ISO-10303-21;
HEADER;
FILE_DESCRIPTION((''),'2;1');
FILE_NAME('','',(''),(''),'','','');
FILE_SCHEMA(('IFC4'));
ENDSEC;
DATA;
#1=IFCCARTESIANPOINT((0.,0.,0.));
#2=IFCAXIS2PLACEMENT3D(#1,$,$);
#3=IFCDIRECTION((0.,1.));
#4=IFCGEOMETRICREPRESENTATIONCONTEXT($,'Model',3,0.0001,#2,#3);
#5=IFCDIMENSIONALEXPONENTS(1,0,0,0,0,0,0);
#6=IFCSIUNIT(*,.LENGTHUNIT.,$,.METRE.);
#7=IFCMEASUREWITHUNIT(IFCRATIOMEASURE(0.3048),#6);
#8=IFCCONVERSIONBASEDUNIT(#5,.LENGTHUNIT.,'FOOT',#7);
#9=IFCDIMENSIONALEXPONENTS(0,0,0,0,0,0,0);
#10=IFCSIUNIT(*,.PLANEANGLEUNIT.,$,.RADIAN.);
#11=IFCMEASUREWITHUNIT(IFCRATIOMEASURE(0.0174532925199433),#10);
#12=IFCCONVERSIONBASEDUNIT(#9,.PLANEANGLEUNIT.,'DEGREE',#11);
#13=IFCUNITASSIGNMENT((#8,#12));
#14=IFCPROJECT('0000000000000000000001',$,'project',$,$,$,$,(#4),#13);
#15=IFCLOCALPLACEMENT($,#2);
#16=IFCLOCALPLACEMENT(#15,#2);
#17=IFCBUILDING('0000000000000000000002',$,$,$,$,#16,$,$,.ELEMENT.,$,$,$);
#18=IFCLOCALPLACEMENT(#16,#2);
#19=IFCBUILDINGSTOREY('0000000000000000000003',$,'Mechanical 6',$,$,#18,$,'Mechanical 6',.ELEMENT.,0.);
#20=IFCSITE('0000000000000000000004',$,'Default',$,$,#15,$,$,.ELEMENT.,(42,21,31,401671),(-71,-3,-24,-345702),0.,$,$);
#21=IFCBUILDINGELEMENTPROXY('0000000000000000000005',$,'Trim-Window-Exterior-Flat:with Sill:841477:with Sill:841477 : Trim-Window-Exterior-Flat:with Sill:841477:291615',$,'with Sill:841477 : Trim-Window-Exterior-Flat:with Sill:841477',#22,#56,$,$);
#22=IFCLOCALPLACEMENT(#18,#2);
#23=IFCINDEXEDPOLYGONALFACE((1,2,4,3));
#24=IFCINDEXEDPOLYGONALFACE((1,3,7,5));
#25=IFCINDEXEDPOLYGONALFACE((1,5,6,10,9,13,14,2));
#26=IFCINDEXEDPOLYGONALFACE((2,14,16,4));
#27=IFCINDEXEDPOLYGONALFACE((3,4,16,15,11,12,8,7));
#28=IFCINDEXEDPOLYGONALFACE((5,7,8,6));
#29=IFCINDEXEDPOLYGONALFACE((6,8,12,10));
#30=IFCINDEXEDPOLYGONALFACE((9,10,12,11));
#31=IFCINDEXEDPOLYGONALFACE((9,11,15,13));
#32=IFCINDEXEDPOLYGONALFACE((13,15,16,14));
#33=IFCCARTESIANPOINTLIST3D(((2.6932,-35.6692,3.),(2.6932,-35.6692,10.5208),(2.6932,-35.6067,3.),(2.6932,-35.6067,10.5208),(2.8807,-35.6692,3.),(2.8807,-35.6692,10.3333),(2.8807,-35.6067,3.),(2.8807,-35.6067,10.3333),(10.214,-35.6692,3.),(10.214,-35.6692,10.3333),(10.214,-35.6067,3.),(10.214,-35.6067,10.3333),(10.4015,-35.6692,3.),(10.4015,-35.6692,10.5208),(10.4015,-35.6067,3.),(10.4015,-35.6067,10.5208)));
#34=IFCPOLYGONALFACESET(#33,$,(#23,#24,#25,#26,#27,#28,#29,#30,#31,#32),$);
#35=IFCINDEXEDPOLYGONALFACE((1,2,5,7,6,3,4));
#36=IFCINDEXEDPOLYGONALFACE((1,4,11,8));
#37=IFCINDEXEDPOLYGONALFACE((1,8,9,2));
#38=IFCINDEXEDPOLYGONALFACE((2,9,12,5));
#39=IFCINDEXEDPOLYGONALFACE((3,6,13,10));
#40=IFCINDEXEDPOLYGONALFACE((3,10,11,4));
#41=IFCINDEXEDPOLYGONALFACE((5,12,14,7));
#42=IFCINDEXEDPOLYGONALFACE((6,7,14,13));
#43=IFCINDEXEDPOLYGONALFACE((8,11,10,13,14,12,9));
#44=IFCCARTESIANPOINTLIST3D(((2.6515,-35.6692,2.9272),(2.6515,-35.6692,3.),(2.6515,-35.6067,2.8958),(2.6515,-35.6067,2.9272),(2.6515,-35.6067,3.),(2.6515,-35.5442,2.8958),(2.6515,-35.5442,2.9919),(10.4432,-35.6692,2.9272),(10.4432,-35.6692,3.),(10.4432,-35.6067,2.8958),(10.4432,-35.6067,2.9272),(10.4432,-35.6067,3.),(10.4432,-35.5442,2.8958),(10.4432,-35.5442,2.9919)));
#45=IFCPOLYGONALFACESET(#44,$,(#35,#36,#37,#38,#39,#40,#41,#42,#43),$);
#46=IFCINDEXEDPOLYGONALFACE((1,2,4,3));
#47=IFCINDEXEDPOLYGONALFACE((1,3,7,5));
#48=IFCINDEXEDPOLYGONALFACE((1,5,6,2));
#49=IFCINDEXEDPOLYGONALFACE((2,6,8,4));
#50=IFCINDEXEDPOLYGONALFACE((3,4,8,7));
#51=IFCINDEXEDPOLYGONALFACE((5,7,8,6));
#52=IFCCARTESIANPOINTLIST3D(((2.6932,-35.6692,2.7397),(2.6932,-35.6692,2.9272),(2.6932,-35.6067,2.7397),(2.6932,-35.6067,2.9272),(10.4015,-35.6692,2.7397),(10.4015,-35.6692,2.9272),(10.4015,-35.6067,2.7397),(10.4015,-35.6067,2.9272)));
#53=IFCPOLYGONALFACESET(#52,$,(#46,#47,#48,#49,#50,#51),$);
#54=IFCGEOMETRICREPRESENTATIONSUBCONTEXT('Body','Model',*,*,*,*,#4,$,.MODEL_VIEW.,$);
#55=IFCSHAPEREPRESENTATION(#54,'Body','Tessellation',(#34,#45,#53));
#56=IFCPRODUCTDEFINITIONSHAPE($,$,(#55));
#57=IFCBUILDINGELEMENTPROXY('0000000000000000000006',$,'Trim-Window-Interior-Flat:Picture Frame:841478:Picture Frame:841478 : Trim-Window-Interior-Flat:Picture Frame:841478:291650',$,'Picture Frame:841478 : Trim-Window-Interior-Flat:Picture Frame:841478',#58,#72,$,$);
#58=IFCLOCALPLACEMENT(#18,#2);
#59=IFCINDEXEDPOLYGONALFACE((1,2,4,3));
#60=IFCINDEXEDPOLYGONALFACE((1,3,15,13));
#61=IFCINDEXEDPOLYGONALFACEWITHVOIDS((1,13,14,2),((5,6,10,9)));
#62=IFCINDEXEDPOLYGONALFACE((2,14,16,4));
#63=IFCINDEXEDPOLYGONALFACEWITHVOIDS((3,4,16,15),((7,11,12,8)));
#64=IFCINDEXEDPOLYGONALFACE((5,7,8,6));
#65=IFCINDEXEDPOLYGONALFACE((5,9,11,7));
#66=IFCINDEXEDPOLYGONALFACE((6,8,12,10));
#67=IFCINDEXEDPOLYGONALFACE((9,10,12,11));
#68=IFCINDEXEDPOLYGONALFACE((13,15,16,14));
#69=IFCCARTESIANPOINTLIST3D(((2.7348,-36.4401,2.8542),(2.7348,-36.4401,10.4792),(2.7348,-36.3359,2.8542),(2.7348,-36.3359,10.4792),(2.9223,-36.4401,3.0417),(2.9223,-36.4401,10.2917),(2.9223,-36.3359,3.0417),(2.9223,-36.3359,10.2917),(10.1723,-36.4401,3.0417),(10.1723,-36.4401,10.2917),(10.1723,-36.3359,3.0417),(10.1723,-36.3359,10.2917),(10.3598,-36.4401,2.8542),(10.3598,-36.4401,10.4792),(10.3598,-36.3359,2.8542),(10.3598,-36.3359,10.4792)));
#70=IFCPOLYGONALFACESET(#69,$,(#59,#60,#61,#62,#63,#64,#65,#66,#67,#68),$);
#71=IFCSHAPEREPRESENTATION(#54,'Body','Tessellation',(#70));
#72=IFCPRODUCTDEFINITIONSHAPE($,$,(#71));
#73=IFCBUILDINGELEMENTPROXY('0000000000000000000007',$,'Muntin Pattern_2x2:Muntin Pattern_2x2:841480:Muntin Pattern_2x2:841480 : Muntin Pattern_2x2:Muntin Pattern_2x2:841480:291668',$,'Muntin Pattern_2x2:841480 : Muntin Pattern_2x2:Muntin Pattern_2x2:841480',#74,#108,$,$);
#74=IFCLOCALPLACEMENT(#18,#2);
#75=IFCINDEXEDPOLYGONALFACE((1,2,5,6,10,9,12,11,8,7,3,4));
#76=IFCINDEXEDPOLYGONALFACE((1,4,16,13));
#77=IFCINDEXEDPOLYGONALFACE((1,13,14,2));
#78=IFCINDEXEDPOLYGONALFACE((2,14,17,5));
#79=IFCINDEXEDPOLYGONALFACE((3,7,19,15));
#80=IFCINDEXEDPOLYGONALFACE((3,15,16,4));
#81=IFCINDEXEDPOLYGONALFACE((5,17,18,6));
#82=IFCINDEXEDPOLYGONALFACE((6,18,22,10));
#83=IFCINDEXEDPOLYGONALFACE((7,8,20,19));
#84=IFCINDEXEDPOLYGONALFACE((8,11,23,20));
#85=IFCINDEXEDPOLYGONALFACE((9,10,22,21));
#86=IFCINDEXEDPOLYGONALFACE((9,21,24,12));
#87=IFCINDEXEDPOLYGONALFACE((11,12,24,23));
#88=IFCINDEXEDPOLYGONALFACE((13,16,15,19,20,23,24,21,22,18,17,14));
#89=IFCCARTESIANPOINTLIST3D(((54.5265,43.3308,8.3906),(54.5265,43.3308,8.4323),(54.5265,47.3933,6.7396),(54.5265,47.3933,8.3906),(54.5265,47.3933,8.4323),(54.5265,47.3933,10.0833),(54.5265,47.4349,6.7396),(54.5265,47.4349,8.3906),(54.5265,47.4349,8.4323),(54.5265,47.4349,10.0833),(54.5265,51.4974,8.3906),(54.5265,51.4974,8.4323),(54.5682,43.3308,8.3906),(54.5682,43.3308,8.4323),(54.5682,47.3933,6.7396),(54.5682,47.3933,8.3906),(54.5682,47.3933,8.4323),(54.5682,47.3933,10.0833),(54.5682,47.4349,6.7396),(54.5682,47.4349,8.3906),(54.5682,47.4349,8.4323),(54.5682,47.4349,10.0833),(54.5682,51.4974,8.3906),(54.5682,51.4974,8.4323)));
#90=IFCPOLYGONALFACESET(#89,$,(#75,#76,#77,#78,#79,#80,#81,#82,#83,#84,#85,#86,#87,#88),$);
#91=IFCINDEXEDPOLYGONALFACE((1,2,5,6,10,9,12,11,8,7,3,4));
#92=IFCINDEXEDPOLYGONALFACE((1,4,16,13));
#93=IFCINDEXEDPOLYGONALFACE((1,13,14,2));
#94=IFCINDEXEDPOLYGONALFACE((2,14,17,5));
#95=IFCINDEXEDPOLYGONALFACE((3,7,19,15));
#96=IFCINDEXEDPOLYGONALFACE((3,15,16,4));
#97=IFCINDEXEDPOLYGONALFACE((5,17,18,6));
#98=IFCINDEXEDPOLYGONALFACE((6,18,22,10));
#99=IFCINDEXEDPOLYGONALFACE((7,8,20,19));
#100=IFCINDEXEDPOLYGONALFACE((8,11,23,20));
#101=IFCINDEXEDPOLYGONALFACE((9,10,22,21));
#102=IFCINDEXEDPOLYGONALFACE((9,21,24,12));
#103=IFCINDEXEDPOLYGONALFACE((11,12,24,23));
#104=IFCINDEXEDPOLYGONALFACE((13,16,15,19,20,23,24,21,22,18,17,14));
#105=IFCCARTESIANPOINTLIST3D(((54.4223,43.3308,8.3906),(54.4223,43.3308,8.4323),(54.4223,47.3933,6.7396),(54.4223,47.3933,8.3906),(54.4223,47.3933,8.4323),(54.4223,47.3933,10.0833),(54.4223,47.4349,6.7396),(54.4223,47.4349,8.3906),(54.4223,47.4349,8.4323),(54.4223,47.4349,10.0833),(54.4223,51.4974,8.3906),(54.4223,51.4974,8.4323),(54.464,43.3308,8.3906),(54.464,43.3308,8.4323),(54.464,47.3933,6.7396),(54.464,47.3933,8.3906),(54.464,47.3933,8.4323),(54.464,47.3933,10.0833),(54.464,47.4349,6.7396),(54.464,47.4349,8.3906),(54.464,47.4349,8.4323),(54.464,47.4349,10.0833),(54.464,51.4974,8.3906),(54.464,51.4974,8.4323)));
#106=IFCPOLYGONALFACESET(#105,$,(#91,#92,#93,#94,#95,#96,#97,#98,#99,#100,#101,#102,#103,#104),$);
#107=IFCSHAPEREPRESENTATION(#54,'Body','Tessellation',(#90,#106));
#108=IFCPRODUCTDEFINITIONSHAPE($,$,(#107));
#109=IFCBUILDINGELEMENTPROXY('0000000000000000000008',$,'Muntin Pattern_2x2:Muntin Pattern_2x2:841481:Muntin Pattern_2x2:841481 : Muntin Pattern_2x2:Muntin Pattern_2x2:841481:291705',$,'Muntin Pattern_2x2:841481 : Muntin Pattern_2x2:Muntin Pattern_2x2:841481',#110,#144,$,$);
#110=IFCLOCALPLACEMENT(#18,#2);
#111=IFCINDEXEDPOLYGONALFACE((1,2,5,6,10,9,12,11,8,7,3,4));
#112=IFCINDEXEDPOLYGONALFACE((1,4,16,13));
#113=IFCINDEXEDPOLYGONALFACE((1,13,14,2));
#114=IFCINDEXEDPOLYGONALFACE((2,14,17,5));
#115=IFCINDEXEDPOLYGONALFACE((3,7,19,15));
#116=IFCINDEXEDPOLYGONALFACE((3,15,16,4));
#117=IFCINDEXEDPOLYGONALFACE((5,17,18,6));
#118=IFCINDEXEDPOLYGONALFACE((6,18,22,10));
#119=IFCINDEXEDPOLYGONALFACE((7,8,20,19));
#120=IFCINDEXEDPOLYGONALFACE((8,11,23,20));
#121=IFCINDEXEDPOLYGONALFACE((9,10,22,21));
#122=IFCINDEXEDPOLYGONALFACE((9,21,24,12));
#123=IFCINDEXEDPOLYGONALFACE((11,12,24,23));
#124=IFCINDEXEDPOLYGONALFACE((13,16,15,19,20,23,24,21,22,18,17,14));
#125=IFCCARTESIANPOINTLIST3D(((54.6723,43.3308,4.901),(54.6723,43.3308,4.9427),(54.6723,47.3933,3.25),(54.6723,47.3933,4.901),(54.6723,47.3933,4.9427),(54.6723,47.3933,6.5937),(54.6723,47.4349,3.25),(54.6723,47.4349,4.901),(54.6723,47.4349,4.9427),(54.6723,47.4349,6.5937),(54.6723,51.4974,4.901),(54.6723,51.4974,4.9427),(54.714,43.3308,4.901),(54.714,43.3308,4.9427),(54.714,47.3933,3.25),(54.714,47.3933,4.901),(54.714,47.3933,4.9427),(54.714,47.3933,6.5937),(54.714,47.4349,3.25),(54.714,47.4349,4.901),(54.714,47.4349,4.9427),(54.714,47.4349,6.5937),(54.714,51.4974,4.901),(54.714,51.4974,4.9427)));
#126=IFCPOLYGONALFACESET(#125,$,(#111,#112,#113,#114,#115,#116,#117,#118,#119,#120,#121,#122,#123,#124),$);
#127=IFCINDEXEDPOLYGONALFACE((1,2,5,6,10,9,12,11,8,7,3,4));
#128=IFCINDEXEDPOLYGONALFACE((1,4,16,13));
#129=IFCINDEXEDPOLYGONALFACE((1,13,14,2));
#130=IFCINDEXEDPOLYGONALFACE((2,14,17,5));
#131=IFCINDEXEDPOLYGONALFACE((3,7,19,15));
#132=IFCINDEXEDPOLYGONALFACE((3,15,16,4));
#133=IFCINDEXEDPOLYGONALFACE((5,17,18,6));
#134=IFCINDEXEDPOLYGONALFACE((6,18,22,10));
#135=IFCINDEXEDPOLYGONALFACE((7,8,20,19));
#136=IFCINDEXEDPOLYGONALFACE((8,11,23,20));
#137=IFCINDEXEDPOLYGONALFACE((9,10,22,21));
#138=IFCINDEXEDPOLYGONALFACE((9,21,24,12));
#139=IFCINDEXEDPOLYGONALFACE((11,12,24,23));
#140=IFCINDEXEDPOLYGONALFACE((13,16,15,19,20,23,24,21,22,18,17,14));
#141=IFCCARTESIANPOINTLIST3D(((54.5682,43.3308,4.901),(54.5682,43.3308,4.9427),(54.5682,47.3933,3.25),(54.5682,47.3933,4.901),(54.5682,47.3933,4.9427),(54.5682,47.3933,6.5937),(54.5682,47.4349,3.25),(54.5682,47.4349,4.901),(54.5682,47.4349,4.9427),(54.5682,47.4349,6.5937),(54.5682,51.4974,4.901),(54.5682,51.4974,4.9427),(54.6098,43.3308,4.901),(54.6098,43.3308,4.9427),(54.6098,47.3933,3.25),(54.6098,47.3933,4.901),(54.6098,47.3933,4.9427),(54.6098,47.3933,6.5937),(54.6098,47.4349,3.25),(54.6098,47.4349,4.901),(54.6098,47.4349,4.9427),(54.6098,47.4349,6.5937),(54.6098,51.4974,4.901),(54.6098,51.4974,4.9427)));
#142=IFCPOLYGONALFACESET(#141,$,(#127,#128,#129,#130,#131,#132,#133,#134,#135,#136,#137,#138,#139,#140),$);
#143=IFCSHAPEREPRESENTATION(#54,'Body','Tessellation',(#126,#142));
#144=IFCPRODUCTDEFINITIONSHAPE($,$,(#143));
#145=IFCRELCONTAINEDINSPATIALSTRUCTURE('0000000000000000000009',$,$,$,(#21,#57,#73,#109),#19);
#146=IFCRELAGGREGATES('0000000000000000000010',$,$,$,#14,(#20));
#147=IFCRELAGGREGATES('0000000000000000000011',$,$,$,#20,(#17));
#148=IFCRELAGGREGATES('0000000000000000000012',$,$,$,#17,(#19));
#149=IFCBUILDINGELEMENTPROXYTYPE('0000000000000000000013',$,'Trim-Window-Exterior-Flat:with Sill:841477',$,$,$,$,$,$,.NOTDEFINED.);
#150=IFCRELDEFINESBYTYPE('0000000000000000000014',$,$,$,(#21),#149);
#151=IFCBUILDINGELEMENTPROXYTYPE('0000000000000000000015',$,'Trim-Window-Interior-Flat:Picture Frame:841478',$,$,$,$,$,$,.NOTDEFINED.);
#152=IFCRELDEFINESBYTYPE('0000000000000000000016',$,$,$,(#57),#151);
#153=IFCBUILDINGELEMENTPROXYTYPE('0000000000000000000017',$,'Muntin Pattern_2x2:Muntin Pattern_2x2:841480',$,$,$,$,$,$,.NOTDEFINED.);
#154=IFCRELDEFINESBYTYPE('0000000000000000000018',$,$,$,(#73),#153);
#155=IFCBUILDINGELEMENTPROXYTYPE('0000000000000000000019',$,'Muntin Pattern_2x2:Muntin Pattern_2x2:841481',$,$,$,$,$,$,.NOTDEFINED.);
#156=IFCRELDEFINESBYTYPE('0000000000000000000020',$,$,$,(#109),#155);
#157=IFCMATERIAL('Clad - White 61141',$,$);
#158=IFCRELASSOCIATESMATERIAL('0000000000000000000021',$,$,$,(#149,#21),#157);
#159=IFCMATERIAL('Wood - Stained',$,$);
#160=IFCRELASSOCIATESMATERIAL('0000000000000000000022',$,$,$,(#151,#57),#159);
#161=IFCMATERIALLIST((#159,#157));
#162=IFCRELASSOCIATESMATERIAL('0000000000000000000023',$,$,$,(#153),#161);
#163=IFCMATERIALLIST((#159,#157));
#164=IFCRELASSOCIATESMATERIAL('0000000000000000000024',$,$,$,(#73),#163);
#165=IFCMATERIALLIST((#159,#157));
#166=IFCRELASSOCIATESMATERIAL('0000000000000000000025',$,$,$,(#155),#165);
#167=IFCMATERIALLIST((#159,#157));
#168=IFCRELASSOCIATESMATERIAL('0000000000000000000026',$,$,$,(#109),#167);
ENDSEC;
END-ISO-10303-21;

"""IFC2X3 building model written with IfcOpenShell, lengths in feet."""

from ifc_helpers import new_model, entity, si_unit, converted_unit, direction, frame, origin, origin_2d_with_axis, place, context, subcontext, project, spatial, polyline, rectangle, outline, extrude, source, transform, mapped, material, material_list, type_object, type_shapes, element, save


model = new_model("IFC2X3")

# Units and contexts
model_context = context("Model", 3, precision=0.0001, world=origin(), true_north=direction((0.0, 1.0)))
body_context = subcontext(model_context, "Body", "Model", "MODEL_VIEW")
ifc_project = project(units=[converted_unit("LENGTHUNIT", "FOOT", entity("IfcRatioMeasure", 0.3048), si_unit("LENGTHUNIT", "METRE"), dimensions=[1, 0, 0, 0, 0, 0, 0]), converted_unit("PLANEANGLEUNIT", "DEGREE", entity("IfcRatioMeasure", 0.0174532925199433), si_unit("PLANEANGLEUNIT", "RADIAN"), dimensions=[0, 0, 0, 0, 0, 0, 0])], contexts=[model_context])

# Site, building, storey
site_placement = place(None, origin())
site = spatial("IfcSite", under=ifc_project, at=site_placement, Name="Default", CompositionType="ELEMENT", RefLatitude=(42, 21, 31, 401671), RefLongitude=(-71, -3, -24, -345702), RefElevation=0.0)
building_placement = place(site_placement, origin())
building = spatial("IfcBuilding", under=site, at=building_placement, CompositionType="ELEMENT")
storey_placement = place(building_placement, origin())
storey = spatial("IfcBuildingStorey", under=building, at=storey_placement, Name="Mechanical 6", LongName="Mechanical 6", CompositionType="ELEMENT", Elevation=0.0)

# Building element proxies
ifc_material_1 = material(Name="Clad - White 61141")
building_element_proxy_type_1 = type_object("IfcBuildingElementProxyType", Name="Trim-Window-Exterior-Flat:with Sill:841477", PredefinedType="NOTDEFINED", material=ifc_material_1)
shared_shape_1 = source(origin(), body_context, "Body", "SweptSolid", [
    extrude(outline(polyline([(-3.8542, -3.7135), (-3.6667, -3.7135), (-3.6667, 3.6198), (3.6667, 3.6198), (3.6667, -3.7135), (3.8542, -3.7135), (3.8542, 3.8073), (-3.8542, 3.8073), (-3.8542, -3.7135)])), frame((6.5473, -35.6692, 6.7135), z_axis=(0.0, 1.0, 0.0), x_axis=(-1.0, 0.0, 0.0)), (0.0, 0.0, 1.0), 0.0625),
    extrude(outline(polyline([(0.0, -0.0525), (0.0625, -0.0525), (0.0625, 0.0436), (0.0, 0.0517), (-0.0625, 0.0517), (-0.0625, -0.0211), (0.0, -0.0211), (0.0, -0.0525)])), frame((2.6515, -35.6067, 2.9483), z_axis=(1.0, 0.0, 0.0), x_axis=(0.0, 1.0, 0.0)), (0.0, 0.0, 1.0), 7.7917),
    extrude(rectangle(XDim=0.0625, YDim=7.7083, at=origin_2d_with_axis()), frame((6.5473, -35.638, 2.7397), z_axis=(0.0, 0.0, 1.0), x_axis=(0.0, -1.0, 0.0)), (0.0, 0.0, 1.0), 0.1875),
])
type_shapes(building_element_proxy_type_1, [shared_shape_1])
proxy_1_placement = place(building_placement, origin())
element("IfcBuildingElementProxy", 1, at=proxy_1_placement, inside=storey, type_object=building_element_proxy_type_1, material=ifc_material_1, Name="Trim-Window-Exterior-Flat:with Sill:841477:with Sill:841477 : Trim-Window-Exterior-Flat:with Sill:841477:291615", ObjectType="with Sill:841477 : Trim-Window-Exterior-Flat:with Sill:841477", context=body_context, shape_type="MappedRepresentation", body=[
    mapped(shared_shape_1, transform((0.0, 0.0, 0.0), scale=1.0)),
])
ifc_material_2 = material(Name="Wood - Stained")
building_element_proxy_type_2 = type_object("IfcBuildingElementProxyType", Name="Trim-Window-Interior-Flat:Picture Frame:841478", PredefinedType="NOTDEFINED", material=ifc_material_2)
shared_shape_2 = source(origin(), body_context, "Body", "SweptSolid", [
    extrude(outline(polyline([(-3.8125, -3.8125), (3.8125, -3.8125), (3.8125, 3.8125), (-3.8125, 3.8125), (-3.8125, -3.8125)]), holes=[polyline([(3.625, 3.625), (3.625, -3.625), (-3.625, -3.625), (-3.625, 3.625), (3.625, 3.625)])]), frame((6.5473, -36.4401, 6.6667), z_axis=(0.0, 1.0, 0.0), x_axis=(1.0, 0.0, 0.0)), (0.0, 0.0, 1.0), 0.1042),
])
type_shapes(building_element_proxy_type_2, [shared_shape_2])
proxy_2_placement = place(building_placement, origin())
element("IfcBuildingElementProxy", 2, at=proxy_2_placement, inside=storey, type_object=building_element_proxy_type_2, material=ifc_material_2, Name="Trim-Window-Interior-Flat:Picture Frame:841478:Picture Frame:841478 : Trim-Window-Interior-Flat:Picture Frame:841478:291650", ObjectType="Picture Frame:841478 : Trim-Window-Interior-Flat:Picture Frame:841478", context=body_context, shape_type="MappedRepresentation", body=[
    mapped(shared_shape_2, transform((0.0, 0.0, 0.0), scale=1.0)),
])
ifc_material_list_1 = material_list([ifc_material_2, ifc_material_1])
ifc_material_list_2 = material_list([ifc_material_2, ifc_material_1])
building_element_proxy_type_3 = type_object("IfcBuildingElementProxyType", Name="Muntin Pattern_2x2:Muntin Pattern_2x2:841480", PredefinedType="NOTDEFINED", material=ifc_material_list_2)
shared_shape_3 = source(origin(), body_context, "Body", "SweptSolid", [
    extrude(outline(polyline([(-1.6719, 0.0208), (-1.6719, -0.0208), (-0.0208, -0.0208), (-0.0208, -4.0833), (0.0208, -4.0833), (0.0208, -0.0208), (1.6719, -0.0208), (1.6719, 0.0208), (0.0208, 0.0208), (0.0208, 4.0833), (-0.0208, 4.0833), (-0.0208, 0.0208), (-1.6719, 0.0208)])), frame((54.5265, 47.4141, 8.4115), z_axis=(-1.0, 0.0, 0.0), x_axis=(0.0, 0.0, -1.0)), (0.0, 0.0, -1.0), 0.0417),
    extrude(outline(polyline([(-1.6719, 0.0208), (-1.6719, -0.0208), (-0.0208, -0.0208), (-0.0208, -4.0833), (0.0208, -4.0833), (0.0208, -0.0208), (1.6719, -0.0208), (1.6719, 0.0208), (0.0208, 0.0208), (0.0208, 4.0833), (-0.0208, 4.0833), (-0.0208, 0.0208), (-1.6719, 0.0208)])), frame((54.4223, 47.4141, 8.4115), z_axis=(-1.0, 0.0, 0.0), x_axis=(0.0, 0.0, -1.0)), (0.0, 0.0, -1.0), 0.0417),
])
type_shapes(building_element_proxy_type_3, [shared_shape_3])
proxy_3_placement = place(building_placement, origin())
element("IfcBuildingElementProxy", 3, at=proxy_3_placement, inside=storey, type_object=building_element_proxy_type_3, material=ifc_material_list_1, Name="Muntin Pattern_2x2:Muntin Pattern_2x2:841480:Muntin Pattern_2x2:841480 : Muntin Pattern_2x2:Muntin Pattern_2x2:841480:291668", ObjectType="Muntin Pattern_2x2:841480 : Muntin Pattern_2x2:Muntin Pattern_2x2:841480", context=body_context, shape_type="MappedRepresentation", body=[
    mapped(shared_shape_3, transform((0.0, 0.0, 0.0), scale=1.0)),
])
ifc_material_list_3 = material_list([ifc_material_2, ifc_material_1])
ifc_material_list_4 = material_list([ifc_material_2, ifc_material_1])
building_element_proxy_type_4 = type_object("IfcBuildingElementProxyType", Name="Muntin Pattern_2x2:Muntin Pattern_2x2:841481", PredefinedType="NOTDEFINED", material=ifc_material_list_4)
shared_shape_4 = source(origin(), body_context, "Body", "SweptSolid", [
    extrude(outline(polyline([(-1.6719, 0.0208), (-1.6719, -0.0208), (-0.0208, -0.0208), (-0.0208, -4.0833), (0.0208, -4.0833), (0.0208, -0.0208), (1.6719, -0.0208), (1.6719, 0.0208), (0.0208, 0.0208), (0.0208, 4.0833), (-0.0208, 4.0833), (-0.0208, 0.0208), (-1.6719, 0.0208)])), frame((54.6723, 47.4141, 4.9219), z_axis=(-1.0, 0.0, 0.0), x_axis=(0.0, 0.0, -1.0)), (0.0, 0.0, -1.0), 0.0417),
    extrude(outline(polyline([(-1.6719, 0.0208), (-1.6719, -0.0208), (-0.0208, -0.0208), (-0.0208, -4.0833), (0.0208, -4.0833), (0.0208, -0.0208), (1.6719, -0.0208), (1.6719, 0.0208), (0.0208, 0.0208), (0.0208, 4.0833), (-0.0208, 4.0833), (-0.0208, 0.0208), (-1.6719, 0.0208)])), frame((54.5682, 47.4141, 4.9219), z_axis=(-1.0, 0.0, 0.0), x_axis=(0.0, 0.0, -1.0)), (0.0, 0.0, -1.0), 0.0417),
])
type_shapes(building_element_proxy_type_4, [shared_shape_4])
proxy_4_placement = place(building_placement, origin())
element("IfcBuildingElementProxy", 4, at=proxy_4_placement, inside=storey, type_object=building_element_proxy_type_4, material=ifc_material_list_3, Name="Muntin Pattern_2x2:Muntin Pattern_2x2:841481:Muntin Pattern_2x2:841481 : Muntin Pattern_2x2:Muntin Pattern_2x2:841481:291705", ObjectType="Muntin Pattern_2x2:841481 : Muntin Pattern_2x2:Muntin Pattern_2x2:841481", context=body_context, shape_type="MappedRepresentation", body=[
    mapped(shared_shape_4, transform((0.0, 0.0, 0.0), scale=1.0)),
])

save(model, "model.ifc")
